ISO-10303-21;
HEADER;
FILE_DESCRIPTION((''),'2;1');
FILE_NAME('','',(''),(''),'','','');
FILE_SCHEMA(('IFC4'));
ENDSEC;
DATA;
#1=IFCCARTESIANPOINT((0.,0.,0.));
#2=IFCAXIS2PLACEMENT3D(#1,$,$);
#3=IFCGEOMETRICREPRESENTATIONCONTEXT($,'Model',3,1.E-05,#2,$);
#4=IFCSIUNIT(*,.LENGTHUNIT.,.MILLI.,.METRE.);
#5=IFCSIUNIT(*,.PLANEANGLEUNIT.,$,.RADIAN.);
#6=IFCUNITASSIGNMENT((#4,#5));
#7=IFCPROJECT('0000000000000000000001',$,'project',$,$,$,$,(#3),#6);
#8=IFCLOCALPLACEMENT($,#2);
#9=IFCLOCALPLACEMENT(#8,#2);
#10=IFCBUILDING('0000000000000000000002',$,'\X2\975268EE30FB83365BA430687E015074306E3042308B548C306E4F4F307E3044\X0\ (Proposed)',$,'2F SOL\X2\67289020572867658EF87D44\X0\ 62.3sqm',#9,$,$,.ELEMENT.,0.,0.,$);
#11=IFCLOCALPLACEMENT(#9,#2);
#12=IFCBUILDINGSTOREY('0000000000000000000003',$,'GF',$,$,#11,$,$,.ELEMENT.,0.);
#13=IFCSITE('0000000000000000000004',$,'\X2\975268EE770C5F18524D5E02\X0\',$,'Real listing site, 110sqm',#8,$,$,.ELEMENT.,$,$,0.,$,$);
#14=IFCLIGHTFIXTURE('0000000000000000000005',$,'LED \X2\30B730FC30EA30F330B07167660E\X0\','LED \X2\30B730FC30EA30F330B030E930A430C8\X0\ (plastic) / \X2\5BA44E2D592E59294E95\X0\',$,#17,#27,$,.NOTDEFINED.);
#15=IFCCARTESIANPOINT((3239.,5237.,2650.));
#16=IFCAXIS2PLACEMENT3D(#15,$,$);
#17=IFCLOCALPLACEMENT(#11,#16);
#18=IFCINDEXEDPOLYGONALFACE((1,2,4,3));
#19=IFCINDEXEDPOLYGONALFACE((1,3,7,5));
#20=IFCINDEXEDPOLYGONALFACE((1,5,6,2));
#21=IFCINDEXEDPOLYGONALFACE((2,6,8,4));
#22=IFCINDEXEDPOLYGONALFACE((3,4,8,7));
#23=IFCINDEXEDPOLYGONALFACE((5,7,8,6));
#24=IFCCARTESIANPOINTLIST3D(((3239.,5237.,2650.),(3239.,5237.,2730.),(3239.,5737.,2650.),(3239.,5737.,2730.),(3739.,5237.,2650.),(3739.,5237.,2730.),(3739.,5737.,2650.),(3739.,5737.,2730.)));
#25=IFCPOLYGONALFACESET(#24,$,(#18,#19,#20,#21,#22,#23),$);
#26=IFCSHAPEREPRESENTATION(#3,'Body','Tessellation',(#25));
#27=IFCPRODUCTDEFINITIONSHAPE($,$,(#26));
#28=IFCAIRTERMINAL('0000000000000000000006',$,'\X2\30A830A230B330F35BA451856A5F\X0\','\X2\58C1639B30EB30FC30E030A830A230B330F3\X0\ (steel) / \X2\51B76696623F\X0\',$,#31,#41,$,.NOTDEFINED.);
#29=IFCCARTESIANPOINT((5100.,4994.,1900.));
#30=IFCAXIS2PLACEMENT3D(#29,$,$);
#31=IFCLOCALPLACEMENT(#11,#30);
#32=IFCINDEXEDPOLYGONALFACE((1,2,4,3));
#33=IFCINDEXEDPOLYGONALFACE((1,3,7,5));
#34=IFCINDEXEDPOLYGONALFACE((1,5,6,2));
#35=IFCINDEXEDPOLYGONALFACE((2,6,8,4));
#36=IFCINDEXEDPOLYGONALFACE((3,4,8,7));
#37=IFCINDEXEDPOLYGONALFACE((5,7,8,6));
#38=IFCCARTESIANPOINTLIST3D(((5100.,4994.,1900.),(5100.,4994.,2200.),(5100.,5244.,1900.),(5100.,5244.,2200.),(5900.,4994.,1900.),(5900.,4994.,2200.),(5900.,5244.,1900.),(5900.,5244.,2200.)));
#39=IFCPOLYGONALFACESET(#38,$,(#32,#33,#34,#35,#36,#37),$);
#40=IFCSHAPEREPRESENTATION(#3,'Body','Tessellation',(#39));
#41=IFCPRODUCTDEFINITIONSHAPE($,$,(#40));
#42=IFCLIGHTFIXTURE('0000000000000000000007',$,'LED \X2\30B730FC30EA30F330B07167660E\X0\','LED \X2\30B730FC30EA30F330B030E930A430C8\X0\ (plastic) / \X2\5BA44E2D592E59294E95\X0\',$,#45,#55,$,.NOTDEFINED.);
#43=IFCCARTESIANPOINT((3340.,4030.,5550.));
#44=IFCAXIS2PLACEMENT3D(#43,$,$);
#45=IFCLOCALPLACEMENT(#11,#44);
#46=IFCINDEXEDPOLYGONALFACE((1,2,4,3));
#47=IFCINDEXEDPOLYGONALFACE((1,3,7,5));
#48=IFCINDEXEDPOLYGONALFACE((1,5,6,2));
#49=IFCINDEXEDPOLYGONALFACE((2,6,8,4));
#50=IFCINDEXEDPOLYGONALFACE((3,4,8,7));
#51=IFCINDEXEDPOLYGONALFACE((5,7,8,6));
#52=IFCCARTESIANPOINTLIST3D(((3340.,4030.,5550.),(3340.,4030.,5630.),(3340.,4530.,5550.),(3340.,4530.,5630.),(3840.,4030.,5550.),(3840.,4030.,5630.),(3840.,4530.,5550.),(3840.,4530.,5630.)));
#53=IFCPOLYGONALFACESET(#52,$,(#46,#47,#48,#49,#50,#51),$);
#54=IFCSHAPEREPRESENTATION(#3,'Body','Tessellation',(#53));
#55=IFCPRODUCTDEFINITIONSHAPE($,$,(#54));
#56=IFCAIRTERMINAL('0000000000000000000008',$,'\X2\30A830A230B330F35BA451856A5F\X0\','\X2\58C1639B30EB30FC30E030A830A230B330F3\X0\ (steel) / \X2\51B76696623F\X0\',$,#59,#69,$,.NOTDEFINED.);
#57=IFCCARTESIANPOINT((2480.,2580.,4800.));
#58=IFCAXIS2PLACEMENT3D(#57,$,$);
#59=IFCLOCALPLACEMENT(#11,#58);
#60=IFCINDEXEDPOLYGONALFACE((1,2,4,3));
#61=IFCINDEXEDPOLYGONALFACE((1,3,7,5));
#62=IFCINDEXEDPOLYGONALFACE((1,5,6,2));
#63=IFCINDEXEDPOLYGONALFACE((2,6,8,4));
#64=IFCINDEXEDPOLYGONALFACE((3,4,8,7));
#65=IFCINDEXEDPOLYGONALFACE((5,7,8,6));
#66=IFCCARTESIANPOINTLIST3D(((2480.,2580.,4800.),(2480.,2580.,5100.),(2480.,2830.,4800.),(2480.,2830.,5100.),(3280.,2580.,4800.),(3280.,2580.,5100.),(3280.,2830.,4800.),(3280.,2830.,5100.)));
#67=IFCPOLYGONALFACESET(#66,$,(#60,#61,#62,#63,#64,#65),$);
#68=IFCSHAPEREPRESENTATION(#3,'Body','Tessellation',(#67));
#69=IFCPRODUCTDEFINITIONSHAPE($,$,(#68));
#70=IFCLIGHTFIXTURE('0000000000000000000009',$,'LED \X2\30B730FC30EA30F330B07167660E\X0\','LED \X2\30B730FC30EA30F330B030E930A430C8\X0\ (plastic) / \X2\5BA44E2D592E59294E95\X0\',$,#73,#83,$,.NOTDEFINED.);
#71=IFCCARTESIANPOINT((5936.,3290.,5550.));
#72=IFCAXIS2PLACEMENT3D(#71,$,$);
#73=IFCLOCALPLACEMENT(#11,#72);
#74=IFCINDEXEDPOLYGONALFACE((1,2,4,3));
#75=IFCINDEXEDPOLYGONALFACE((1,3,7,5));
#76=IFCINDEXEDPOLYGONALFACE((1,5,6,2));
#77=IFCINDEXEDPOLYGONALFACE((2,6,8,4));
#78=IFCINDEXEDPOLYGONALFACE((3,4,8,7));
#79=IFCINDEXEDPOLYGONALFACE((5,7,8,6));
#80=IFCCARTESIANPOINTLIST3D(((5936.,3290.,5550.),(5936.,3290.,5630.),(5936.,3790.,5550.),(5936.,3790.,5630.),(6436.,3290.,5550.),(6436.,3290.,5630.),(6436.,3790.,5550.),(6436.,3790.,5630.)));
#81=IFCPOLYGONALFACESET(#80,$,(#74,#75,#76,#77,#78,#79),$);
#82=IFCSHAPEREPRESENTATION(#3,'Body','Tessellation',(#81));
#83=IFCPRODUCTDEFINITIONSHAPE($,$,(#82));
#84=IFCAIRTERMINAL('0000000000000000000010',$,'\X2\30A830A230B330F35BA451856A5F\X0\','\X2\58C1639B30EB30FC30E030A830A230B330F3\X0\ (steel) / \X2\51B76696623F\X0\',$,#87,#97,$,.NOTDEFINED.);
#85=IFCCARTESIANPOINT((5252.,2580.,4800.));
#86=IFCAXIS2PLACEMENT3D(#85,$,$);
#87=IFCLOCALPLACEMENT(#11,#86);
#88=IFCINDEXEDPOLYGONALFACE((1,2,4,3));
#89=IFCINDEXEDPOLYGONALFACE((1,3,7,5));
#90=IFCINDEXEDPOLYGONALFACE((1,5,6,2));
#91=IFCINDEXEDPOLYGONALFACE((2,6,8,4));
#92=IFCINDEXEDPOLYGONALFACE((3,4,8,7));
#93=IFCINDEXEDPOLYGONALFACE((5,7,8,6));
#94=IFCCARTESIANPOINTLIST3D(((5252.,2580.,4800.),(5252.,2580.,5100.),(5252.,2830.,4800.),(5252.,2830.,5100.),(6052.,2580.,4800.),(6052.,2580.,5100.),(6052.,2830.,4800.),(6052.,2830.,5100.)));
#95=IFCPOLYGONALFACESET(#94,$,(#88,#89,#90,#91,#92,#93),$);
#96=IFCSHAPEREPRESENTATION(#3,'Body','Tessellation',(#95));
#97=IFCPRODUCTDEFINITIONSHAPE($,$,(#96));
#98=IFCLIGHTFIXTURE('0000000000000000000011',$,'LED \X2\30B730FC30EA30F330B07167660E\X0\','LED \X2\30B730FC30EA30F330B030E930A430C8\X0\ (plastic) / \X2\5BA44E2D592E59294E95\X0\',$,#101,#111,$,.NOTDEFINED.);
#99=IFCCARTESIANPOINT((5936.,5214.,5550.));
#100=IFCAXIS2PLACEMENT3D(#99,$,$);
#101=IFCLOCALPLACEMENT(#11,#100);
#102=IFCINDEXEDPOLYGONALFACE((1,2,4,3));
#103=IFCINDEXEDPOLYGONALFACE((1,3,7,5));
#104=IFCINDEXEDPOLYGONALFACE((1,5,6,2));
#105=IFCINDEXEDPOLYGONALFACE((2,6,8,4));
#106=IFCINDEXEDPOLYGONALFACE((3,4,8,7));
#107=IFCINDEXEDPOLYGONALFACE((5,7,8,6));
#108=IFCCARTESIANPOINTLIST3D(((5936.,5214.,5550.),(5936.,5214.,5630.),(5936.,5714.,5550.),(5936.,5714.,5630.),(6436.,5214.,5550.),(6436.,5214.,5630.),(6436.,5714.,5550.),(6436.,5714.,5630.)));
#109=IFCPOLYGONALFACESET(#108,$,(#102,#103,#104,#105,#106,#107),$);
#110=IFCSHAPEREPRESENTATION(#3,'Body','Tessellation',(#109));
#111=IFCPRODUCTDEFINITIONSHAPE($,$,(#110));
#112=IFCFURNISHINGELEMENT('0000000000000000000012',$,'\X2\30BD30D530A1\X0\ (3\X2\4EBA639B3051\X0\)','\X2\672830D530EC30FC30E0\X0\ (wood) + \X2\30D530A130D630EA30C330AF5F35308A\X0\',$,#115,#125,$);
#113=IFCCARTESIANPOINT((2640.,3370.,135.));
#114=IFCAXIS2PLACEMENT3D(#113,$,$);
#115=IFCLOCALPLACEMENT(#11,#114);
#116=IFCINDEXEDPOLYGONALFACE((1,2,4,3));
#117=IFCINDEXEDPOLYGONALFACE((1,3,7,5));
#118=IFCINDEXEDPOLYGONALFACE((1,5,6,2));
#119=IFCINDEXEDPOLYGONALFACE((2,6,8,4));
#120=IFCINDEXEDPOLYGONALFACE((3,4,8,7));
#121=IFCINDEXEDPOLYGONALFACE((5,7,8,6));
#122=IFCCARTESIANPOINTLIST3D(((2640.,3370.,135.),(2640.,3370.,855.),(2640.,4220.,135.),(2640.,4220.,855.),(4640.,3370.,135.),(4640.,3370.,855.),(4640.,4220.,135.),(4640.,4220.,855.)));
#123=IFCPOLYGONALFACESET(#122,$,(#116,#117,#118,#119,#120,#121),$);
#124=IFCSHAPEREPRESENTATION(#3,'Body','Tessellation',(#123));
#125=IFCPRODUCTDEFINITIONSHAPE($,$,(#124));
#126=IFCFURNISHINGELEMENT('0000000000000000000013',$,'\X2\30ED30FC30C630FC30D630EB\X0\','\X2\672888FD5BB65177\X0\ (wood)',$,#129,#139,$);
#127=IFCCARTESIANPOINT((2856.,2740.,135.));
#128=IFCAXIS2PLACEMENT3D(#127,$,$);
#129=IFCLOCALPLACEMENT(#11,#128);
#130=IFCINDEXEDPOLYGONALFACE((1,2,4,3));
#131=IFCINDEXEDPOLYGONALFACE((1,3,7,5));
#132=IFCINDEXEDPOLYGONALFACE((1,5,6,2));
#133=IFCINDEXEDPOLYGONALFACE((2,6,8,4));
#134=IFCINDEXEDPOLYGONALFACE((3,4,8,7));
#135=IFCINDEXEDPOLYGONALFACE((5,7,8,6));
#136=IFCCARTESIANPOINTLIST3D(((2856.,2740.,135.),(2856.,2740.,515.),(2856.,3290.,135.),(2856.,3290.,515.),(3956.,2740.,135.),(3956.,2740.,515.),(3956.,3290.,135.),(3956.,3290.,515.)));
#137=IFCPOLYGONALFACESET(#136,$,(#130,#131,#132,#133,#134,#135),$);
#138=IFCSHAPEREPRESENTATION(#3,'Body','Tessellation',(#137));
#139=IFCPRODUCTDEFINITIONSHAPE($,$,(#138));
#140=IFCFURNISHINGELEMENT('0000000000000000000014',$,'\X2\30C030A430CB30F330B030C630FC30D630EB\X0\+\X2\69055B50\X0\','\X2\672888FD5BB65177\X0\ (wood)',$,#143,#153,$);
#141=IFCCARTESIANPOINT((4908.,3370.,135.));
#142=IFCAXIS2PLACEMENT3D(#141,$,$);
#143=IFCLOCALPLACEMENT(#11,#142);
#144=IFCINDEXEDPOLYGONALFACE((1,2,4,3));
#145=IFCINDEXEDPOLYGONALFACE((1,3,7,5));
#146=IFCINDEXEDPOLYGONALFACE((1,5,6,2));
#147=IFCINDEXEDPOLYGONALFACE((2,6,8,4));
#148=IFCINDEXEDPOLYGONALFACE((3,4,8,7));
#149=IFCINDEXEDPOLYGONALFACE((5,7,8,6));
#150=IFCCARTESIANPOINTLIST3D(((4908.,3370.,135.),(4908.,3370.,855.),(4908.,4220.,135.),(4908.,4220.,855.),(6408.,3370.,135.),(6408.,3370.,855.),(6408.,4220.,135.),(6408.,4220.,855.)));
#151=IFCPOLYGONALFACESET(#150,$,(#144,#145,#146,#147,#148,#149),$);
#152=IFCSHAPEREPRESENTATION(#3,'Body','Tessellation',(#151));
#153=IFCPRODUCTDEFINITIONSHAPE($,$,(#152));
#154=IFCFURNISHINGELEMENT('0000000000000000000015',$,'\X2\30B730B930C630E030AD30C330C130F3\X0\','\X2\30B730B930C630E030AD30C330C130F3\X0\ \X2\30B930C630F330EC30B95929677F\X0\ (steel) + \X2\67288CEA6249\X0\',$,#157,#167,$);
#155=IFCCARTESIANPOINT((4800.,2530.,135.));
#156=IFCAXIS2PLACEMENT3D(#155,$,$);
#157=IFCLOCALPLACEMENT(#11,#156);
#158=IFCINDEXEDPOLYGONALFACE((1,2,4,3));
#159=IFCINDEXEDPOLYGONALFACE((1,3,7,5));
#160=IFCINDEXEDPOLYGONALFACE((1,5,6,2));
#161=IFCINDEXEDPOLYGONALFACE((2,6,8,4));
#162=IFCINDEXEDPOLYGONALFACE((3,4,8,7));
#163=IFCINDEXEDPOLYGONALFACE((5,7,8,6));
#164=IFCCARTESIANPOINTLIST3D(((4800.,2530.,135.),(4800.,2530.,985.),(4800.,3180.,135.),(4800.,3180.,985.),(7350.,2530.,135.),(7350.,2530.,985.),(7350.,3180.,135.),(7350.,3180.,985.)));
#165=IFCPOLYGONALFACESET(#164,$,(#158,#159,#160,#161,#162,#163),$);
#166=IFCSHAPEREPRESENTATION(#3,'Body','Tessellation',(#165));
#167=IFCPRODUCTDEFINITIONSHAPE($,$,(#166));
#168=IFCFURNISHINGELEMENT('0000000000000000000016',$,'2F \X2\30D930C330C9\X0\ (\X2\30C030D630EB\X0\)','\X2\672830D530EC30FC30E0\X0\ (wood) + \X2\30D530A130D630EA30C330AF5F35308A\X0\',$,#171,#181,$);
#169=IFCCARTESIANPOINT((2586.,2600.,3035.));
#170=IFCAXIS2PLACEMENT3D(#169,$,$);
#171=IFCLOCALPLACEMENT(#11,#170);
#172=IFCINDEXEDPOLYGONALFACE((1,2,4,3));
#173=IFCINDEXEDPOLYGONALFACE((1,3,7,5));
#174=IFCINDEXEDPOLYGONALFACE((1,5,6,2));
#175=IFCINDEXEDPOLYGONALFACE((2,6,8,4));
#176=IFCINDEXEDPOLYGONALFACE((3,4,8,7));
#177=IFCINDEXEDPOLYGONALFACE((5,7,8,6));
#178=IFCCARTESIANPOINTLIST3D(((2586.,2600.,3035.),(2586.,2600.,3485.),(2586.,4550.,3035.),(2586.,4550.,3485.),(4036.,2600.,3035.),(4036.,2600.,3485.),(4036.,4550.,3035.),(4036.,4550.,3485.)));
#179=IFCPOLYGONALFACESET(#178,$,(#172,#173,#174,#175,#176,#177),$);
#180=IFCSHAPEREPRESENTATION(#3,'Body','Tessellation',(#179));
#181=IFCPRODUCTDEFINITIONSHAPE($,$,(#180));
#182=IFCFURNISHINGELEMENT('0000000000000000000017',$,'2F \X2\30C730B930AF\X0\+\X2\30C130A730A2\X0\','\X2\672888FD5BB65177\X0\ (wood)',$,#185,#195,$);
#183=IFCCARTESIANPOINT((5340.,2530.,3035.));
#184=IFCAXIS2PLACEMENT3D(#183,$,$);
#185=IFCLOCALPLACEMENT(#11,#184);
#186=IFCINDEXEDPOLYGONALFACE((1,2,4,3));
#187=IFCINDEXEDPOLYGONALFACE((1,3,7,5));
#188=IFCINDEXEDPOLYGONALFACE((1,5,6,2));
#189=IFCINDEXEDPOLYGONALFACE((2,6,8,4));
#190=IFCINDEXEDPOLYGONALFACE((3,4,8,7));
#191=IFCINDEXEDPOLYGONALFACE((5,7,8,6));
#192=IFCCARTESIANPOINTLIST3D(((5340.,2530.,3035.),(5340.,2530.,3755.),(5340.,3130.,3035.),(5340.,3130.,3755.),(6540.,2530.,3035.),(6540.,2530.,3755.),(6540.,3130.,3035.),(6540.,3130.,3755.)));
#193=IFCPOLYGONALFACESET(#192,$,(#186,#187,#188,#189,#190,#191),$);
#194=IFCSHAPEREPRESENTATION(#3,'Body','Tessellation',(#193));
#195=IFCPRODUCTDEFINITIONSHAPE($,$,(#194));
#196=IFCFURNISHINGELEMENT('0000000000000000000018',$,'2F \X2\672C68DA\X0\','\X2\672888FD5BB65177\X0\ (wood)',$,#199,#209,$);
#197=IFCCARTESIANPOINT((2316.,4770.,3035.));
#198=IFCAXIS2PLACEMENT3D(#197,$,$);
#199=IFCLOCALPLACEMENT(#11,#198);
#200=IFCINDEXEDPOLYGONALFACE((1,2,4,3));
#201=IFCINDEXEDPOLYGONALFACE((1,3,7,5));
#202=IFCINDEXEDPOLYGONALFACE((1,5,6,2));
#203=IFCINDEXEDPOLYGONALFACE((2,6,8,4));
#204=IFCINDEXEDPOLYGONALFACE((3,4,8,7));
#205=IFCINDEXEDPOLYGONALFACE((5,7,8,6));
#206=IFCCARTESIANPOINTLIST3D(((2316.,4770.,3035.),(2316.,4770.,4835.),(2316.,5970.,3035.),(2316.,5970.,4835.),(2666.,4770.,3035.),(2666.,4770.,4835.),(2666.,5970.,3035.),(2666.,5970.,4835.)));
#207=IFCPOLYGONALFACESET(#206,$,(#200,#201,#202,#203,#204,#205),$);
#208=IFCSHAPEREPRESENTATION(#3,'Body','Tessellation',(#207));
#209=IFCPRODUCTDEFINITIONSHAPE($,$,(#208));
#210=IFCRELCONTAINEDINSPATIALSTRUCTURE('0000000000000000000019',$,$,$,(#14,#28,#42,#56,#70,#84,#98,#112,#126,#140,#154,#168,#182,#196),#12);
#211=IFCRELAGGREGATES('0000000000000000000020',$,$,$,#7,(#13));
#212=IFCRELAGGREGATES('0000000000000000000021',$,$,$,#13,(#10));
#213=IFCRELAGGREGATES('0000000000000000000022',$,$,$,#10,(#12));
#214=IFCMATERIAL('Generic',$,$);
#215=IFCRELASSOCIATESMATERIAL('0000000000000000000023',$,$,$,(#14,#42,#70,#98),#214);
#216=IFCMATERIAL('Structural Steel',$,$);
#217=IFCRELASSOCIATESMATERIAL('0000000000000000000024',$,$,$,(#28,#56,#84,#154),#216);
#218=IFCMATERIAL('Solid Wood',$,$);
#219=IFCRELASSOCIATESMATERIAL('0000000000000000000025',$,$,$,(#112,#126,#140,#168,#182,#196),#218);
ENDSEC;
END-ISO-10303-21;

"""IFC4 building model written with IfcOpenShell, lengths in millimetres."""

from ifc_helpers import new_model, si_unit, frame, frame_2d, origin, place, context, project, spatial, rectangle, extrude, material, element, save


model = new_model("IFC4")

# Units and contexts
model_context = context("Model", 3, precision=1e-05, world=origin())
ifc_project = project(units=[si_unit("LENGTHUNIT", "METRE", prefix="MILLI"), si_unit("PLANEANGLEUNIT", "RADIAN")], contexts=[model_context])

# Site, building, storey
site_placement = place(None, origin())
site = spatial("IfcSite", under=ifc_project, at=site_placement, Name="青森県弘前市", ObjectType="Real listing site, 110sqm", CompositionType="ELEMENT", RefElevation=0.0)
building_placement = place(site_placement, origin())
building = spatial("IfcBuilding", under=site, at=building_placement, Name="青森・茶室と縁側のある和の住まい (Proposed)", ObjectType="2F SOL木造在来軸組 62.3sqm", CompositionType="ELEMENT", ElevationOfRefHeight=0.0, ElevationOfTerrain=0.0)
storey_placement = place(building_placement, origin())
storey = spatial("IfcBuildingStorey", under=building, at=storey_placement, Name="GF", CompositionType="ELEMENT", Elevation=0.0)

# Shared definitions
ifc_material_1 = material(Name="Solid Wood")

# Shared definitions
ifc_material_2 = material(Name="Structural Steel")

# Shared definitions
ifc_material_3 = material(Name="Generic")

# Light fixture
light_fixture_1_placement = place(storey_placement, frame((3239.0, 5237.0, 2650.0)))
element("IfcLightFixture", 1, at=light_fixture_1_placement, inside=storey, material=ifc_material_3, Name="LED シーリング照明", Description="LED シーリングライト (plastic) / 室中央天井", PredefinedType="NOTDEFINED", context=model_context, shape_type="SweptSolid", body=[
    extrude(rectangle(XDim=500.0, YDim=500.0, at=frame_2d((250.0, 250.0))), frame((3239.0, 5237.0, 2650.0)), (0.0, 0.0, 1.0), 80.0),
])

# Air terminal
air_terminal_1_placement = place(storey_placement, frame((5100.0, 4994.0, 1900.0)))
element("IfcAirTerminal", 2, at=air_terminal_1_placement, inside=storey, material=ifc_material_2, Name="エアコン室内機", Description="壁掛ルームエアコン (steel) / 冷暖房", PredefinedType="NOTDEFINED", context=model_context, shape_type="SweptSolid", body=[
    extrude(rectangle(XDim=800.0, YDim=250.0, at=frame_2d((400.0, 125.0))), frame((5100.0, 4994.0, 1900.0)), (0.0, 0.0, 1.0), 300.0),
])

# Light fixture
light_fixture_2_placement = place(storey_placement, frame((3340.0, 4030.0, 5550.0)))
element("IfcLightFixture", 3, at=light_fixture_2_placement, inside=storey, material=ifc_material_3, Name="LED シーリング照明", Description="LED シーリングライト (plastic) / 室中央天井", PredefinedType="NOTDEFINED", context=model_context, shape_type="SweptSolid", body=[
    extrude(rectangle(XDim=500.0, YDim=500.0, at=frame_2d((250.0, 250.0))), frame((3340.0, 4030.0, 5550.0)), (0.0, 0.0, 1.0), 80.0),
])

# Air terminal
air_terminal_2_placement = place(storey_placement, frame((2480.0, 2580.0, 4800.0)))
element("IfcAirTerminal", 4, at=air_terminal_2_placement, inside=storey, material=ifc_material_2, Name="エアコン室内機", Description="壁掛ルームエアコン (steel) / 冷暖房", PredefinedType="NOTDEFINED", context=model_context, shape_type="SweptSolid", body=[
    extrude(rectangle(XDim=800.0, YDim=250.0, at=frame_2d((400.0, 125.0))), frame((2480.0, 2580.0, 4800.0)), (0.0, 0.0, 1.0), 300.0),
])

# Light fixture
light_fixture_3_placement = place(storey_placement, frame((5936.0, 3290.0, 5550.0)))
element("IfcLightFixture", 5, at=light_fixture_3_placement, inside=storey, material=ifc_material_3, Name="LED シーリング照明", Description="LED シーリングライト (plastic) / 室中央天井", PredefinedType="NOTDEFINED", context=model_context, shape_type="SweptSolid", body=[
    extrude(rectangle(XDim=500.0, YDim=500.0, at=frame_2d((250.0, 250.0))), frame((5936.0, 3290.0, 5550.0)), (0.0, 0.0, 1.0), 80.0),
])

# Air terminal
air_terminal_3_placement = place(storey_placement, frame((5252.0, 2580.0, 4800.0)))
element("IfcAirTerminal", 6, at=air_terminal_3_placement, inside=storey, material=ifc_material_2, Name="エアコン室内機", Description="壁掛ルームエアコン (steel) / 冷暖房", PredefinedType="NOTDEFINED", context=model_context, shape_type="SweptSolid", body=[
    extrude(rectangle(XDim=800.0, YDim=250.0, at=frame_2d((400.0, 125.0))), frame((5252.0, 2580.0, 4800.0)), (0.0, 0.0, 1.0), 300.0),
])

# Light fixture
light_fixture_4_placement = place(storey_placement, frame((5936.0, 5214.0, 5550.0)))
element("IfcLightFixture", 7, at=light_fixture_4_placement, inside=storey, material=ifc_material_3, Name="LED シーリング照明", Description="LED シーリングライト (plastic) / 室中央天井", PredefinedType="NOTDEFINED", context=model_context, shape_type="SweptSolid", body=[
    extrude(rectangle(XDim=500.0, YDim=500.0, at=frame_2d((250.0, 250.0))), frame((5936.0, 5214.0, 5550.0)), (0.0, 0.0, 1.0), 80.0),
])

# Furnishing elements
furnishing_1_placement = place(storey_placement, frame((2640.0, 3370.0, 135.0)))
element("IfcFurnishingElement", 8, at=furnishing_1_placement, inside=storey, material=ifc_material_1, Name="ソファ (3人掛け)", Description="木フレーム (wood) + ファブリック張り", context=model_context, shape_type="SweptSolid", body=[
    extrude(rectangle(XDim=2000.0, YDim=850.0, at=frame_2d((1000.0, 425.0))), frame((2640.0, 3370.0, 135.0)), (0.0, 0.0, 1.0), 720.0),
])
furnishing_2_placement = place(storey_placement, frame((2856.0, 2740.0, 135.0)))
element("IfcFurnishingElement", 9, at=furnishing_2_placement, inside=storey, material=ifc_material_1, Name="ローテーブル", Description="木製家具 (wood)", context=model_context, shape_type="SweptSolid", body=[
    extrude(rectangle(XDim=1100.0, YDim=550.0, at=frame_2d((550.0, 275.0))), frame((2856.0, 2740.0, 135.0)), (0.0, 0.0, 1.0), 380.0),
])
furnishing_3_placement = place(storey_placement, frame((4908.0, 3370.0, 135.0)))
element("IfcFurnishingElement", 10, at=furnishing_3_placement, inside=storey, material=ifc_material_1, Name="ダイニングテーブル+椅子", Description="木製家具 (wood)", context=model_context, shape_type="SweptSolid", body=[
    extrude(rectangle(XDim=1500.0, YDim=850.0, at=frame_2d((750.0, 425.0))), frame((4908.0, 3370.0, 135.0)), (0.0, 0.0, 1.0), 720.0),
])
furnishing_4_placement = place(storey_placement, frame((4800.0, 2530.0, 135.0)))
element("IfcFurnishingElement", 11, at=furnishing_4_placement, inside=storey, material=ifc_material_2, Name="システムキッチン", Description="システムキッチン ステンレス天板 (steel) + 木質扉", context=model_context, shape_type="SweptSolid", body=[
    extrude(rectangle(XDim=2550.0, YDim=650.0, at=frame_2d((1275.0, 325.0))), frame((4800.0, 2530.0, 135.0)), (0.0, 0.0, 1.0), 850.0),
])
furnishing_5_placement = place(storey_placement, frame((2586.0, 2600.0, 3035.0)))
element("IfcFurnishingElement", 12, at=furnishing_5_placement, inside=storey, material=ifc_material_1, Name="2F ベッド (ダブル)", Description="木フレーム (wood) + ファブリック張り", context=model_context, shape_type="SweptSolid", body=[
    extrude(rectangle(XDim=1450.0, YDim=1950.0, at=frame_2d((725.0, 975.0))), frame((2586.0, 2600.0, 3035.0)), (0.0, 0.0, 1.0), 450.0),
])
furnishing_6_placement = place(storey_placement, frame((5340.0, 2530.0, 3035.0)))
element("IfcFurnishingElement", 13, at=furnishing_6_placement, inside=storey, material=ifc_material_1, Name="2F デスク+チェア", Description="木製家具 (wood)", context=model_context, shape_type="SweptSolid", body=[
    extrude(rectangle(XDim=1200.0, YDim=600.0, at=frame_2d((600.0, 300.0))), frame((5340.0, 2530.0, 3035.0)), (0.0, 0.0, 1.0), 720.0),
])
furnishing_7_placement = place(storey_placement, frame((2316.0, 4770.0, 3035.0)))
element("IfcFurnishingElement", 14, at=furnishing_7_placement, inside=storey, material=ifc_material_1, Name="2F 本棚", Description="木製家具 (wood)", context=model_context, shape_type="SweptSolid", body=[
    extrude(rectangle(XDim=350.0, YDim=1200.0, at=frame_2d((175.0, 600.0))), frame((2316.0, 4770.0, 3035.0)), (0.0, 0.0, 1.0), 1800.0),
])

save(model, "model.ifc")
